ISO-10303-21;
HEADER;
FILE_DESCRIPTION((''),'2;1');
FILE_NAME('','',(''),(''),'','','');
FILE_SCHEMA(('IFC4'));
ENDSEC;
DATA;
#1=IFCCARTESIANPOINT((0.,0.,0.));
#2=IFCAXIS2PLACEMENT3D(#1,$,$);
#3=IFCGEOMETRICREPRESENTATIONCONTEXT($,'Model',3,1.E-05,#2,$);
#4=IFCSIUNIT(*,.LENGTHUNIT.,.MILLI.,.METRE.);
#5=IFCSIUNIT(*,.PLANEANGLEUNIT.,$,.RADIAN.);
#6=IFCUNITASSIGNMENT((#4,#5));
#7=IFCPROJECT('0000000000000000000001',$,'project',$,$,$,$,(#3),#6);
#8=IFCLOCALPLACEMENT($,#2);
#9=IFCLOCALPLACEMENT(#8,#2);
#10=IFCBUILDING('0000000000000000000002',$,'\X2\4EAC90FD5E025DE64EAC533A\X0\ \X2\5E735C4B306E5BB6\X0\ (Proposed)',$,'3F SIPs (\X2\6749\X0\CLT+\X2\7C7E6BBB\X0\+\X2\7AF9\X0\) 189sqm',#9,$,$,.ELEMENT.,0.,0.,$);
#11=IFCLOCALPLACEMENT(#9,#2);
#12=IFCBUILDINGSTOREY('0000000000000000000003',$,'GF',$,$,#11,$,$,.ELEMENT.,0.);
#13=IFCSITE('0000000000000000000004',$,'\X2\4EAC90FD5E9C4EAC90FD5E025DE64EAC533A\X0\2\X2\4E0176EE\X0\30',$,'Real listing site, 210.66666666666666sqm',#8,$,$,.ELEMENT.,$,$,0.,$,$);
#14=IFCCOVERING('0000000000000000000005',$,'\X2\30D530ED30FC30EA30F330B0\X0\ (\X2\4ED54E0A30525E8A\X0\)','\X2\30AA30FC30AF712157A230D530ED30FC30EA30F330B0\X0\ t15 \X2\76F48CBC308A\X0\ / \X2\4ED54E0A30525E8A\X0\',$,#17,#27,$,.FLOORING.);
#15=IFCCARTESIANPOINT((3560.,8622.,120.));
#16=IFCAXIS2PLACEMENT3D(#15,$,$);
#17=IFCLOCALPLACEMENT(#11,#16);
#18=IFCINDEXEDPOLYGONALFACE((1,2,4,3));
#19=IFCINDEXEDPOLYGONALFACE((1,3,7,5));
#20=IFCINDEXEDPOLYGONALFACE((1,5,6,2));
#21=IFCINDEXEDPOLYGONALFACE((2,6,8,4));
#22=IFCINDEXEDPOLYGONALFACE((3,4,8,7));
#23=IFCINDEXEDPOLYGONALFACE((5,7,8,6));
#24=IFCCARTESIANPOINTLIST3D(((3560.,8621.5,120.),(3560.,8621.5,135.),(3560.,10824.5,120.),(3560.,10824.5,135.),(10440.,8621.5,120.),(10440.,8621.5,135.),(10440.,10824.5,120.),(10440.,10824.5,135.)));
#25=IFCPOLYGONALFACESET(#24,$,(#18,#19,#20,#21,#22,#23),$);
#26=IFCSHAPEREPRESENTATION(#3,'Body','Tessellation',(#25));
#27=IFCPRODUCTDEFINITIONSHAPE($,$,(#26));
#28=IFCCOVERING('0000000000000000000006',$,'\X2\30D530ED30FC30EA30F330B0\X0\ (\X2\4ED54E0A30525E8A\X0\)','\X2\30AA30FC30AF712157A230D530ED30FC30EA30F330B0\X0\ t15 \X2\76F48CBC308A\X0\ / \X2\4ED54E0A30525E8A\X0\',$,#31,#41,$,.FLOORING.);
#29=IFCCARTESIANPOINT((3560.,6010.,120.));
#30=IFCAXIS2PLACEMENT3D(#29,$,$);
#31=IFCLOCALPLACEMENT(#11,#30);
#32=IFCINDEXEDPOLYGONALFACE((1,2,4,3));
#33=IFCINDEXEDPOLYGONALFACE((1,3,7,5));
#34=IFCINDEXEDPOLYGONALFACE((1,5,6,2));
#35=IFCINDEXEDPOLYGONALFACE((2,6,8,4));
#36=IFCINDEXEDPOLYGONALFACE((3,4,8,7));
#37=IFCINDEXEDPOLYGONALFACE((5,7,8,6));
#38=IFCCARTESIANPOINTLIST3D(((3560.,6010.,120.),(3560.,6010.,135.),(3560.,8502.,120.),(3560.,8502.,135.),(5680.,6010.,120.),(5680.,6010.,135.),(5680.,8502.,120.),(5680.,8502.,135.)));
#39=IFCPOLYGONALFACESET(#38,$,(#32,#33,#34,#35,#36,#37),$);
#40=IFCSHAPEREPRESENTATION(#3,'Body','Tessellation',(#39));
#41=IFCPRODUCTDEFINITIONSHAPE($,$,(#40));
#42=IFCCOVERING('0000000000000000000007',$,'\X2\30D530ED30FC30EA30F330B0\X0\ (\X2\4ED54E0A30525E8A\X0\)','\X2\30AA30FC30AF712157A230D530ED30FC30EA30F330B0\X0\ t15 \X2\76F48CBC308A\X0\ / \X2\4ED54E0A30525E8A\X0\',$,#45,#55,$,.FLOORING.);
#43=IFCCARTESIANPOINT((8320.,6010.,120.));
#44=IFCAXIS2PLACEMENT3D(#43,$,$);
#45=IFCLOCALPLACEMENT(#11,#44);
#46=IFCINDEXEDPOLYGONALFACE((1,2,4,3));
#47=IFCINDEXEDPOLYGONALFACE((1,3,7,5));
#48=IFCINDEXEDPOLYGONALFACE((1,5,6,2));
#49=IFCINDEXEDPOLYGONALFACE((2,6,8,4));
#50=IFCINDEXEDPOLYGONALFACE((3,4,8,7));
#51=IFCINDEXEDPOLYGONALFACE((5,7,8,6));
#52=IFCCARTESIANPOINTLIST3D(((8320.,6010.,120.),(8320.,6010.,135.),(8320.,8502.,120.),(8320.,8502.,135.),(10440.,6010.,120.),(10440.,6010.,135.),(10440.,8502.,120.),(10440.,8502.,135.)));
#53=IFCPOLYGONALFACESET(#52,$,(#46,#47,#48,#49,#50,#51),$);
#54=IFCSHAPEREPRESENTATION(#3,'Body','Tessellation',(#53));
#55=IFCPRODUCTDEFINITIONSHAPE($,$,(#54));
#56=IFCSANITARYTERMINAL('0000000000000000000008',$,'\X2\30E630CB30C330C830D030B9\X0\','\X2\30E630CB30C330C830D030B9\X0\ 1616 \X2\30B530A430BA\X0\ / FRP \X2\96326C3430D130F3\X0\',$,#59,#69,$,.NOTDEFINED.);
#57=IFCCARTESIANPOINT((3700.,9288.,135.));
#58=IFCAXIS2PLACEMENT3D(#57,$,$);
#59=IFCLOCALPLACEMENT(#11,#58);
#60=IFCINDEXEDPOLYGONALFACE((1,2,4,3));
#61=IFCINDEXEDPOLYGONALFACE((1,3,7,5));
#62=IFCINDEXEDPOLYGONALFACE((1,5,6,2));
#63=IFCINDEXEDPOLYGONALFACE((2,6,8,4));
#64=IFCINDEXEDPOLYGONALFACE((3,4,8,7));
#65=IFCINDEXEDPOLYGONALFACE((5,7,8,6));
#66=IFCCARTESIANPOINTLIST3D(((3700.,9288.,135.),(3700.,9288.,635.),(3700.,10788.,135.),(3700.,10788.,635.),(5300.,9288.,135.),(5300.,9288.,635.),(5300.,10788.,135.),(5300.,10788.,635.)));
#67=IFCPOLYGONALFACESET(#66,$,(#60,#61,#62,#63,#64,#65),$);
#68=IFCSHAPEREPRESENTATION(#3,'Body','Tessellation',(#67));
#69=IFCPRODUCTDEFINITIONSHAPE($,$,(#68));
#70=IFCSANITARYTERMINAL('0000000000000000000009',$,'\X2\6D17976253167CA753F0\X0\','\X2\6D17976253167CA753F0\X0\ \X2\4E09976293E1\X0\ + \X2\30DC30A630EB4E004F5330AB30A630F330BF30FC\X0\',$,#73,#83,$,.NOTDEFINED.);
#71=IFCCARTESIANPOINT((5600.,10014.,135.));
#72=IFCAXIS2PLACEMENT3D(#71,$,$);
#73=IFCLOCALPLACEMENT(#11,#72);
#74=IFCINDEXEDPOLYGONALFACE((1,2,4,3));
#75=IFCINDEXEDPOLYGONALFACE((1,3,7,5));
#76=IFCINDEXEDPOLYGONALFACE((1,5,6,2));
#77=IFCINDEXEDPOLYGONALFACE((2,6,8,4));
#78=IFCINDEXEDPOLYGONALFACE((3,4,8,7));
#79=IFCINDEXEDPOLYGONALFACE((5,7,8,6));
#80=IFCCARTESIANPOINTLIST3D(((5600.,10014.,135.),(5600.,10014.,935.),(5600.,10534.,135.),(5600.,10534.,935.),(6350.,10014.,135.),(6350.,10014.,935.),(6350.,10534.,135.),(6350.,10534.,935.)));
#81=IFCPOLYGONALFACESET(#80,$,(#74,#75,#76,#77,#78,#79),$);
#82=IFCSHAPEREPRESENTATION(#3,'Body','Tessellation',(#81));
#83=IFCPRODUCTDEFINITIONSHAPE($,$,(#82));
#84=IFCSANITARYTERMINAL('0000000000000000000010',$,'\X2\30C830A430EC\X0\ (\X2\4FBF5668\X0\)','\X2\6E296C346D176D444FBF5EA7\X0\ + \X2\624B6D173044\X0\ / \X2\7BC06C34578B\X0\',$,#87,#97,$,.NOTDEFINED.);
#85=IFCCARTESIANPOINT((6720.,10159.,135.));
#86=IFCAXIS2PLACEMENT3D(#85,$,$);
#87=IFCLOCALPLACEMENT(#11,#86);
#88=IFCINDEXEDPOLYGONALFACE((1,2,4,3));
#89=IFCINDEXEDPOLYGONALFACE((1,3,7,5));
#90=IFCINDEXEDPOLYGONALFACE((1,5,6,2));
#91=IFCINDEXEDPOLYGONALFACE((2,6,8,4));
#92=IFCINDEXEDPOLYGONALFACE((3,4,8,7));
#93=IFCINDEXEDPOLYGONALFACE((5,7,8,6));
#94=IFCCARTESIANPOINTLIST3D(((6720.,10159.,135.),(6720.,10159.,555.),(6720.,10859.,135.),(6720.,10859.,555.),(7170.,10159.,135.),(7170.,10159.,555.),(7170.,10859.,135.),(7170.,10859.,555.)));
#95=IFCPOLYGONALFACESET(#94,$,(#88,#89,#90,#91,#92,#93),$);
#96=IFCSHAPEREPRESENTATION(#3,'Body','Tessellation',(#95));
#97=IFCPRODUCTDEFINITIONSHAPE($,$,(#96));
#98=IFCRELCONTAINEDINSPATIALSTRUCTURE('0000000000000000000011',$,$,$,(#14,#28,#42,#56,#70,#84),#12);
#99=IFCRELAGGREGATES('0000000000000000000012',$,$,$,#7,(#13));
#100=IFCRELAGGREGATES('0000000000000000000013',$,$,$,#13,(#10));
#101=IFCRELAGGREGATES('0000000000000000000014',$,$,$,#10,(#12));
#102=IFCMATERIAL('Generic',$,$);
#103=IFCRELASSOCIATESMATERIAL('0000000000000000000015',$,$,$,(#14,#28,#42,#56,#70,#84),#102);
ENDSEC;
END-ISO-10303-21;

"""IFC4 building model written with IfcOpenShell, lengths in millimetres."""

from ifc_helpers import new_model, si_unit, frame, frame_2d, origin, place, context, project, spatial, rectangle, extrude, material, element, save


model = new_model("IFC4")

# Units and contexts
model_context = context("Model", 3, precision=1e-05, world=origin())
ifc_project = project(units=[si_unit("LENGTHUNIT", "METRE", prefix="MILLI"), si_unit("PLANEANGLEUNIT", "RADIAN")], contexts=[model_context])

# Site, building, storey
site_placement = place(None, origin())
site = spatial("IfcSite", under=ifc_project, at=site_placement, Name="京都府京都市左京区2丁目30", ObjectType="Real listing site, 210.66666666666666sqm", CompositionType="ELEMENT", RefElevation=0.0)
building_placement = place(site_placement, origin())
building = spatial("IfcBuilding", under=site, at=building_placement, Name="京都市左京区 平屋の家 (Proposed)", ObjectType="3F SIPs (杉CLT+籾殻+竹) 189sqm", CompositionType="ELEMENT", ElevationOfRefHeight=0.0, ElevationOfTerrain=0.0)
storey_placement = place(building_placement, origin())
storey = spatial("IfcBuildingStorey", under=building, at=storey_placement, Name="GF", CompositionType="ELEMENT", Elevation=0.0)

# Coverings
ifc_material_1 = material(Name="Generic")
covering_1_placement = place(storey_placement, frame((3560.0, 8622.0, 120.0)))
element("IfcCovering", 1, at=covering_1_placement, inside=storey, material=ifc_material_1, Name="フローリング (仕上げ床)", Description="オーク無垢フローリング t15 直貼り / 仕上げ床", PredefinedType="FLOORING", context=model_context, shape_type="SweptSolid", body=[
    extrude(rectangle(XDim=6880.0, YDim=2203.0, at=frame_2d((3440.0, 1101.0))), frame((3560.0, 8622.0, 120.0)), (0.0, 0.0, 1.0), 15.0),
])
covering_2_placement = place(storey_placement, frame((3560.0, 6010.0, 120.0)))
element("IfcCovering", 2, at=covering_2_placement, inside=storey, material=ifc_material_1, Name="フローリング (仕上げ床)", Description="オーク無垢フローリング t15 直貼り / 仕上げ床", PredefinedType="FLOORING", context=model_context, shape_type="SweptSolid", body=[
    extrude(rectangle(XDim=2120.0, YDim=2492.0, at=frame_2d((1060.0, 1246.0))), frame((3560.0, 6010.0, 120.0)), (0.0, 0.0, 1.0), 15.0),
])
covering_3_placement = place(storey_placement, frame((8320.0, 6010.0, 120.0)))
element("IfcCovering", 3, at=covering_3_placement, inside=storey, material=ifc_material_1, Name="フローリング (仕上げ床)", Description="オーク無垢フローリング t15 直貼り / 仕上げ床", PredefinedType="FLOORING", context=model_context, shape_type="SweptSolid", body=[
    extrude(rectangle(XDim=2120.0, YDim=2492.0, at=frame_2d((1060.0, 1246.0))), frame((8320.0, 6010.0, 120.0)), (0.0, 0.0, 1.0), 15.0),
])

# Sanitary terminals
sanitary_terminal_1_placement = place(storey_placement, frame((3700.0, 9288.0, 135.0)))
element("IfcSanitaryTerminal", 4, at=sanitary_terminal_1_placement, inside=storey, material=ifc_material_1, Name="ユニットバス", Description="ユニットバス 1616 サイズ / FRP 防水パン", PredefinedType="NOTDEFINED", context=model_context, shape_type="SweptSolid", body=[
    extrude(rectangle(XDim=1600.0, YDim=1500.0, at=frame_2d((800.0, 750.0))), frame((3700.0, 9288.0, 135.0)), (0.0, 0.0, 1.0), 500.0),
])
sanitary_terminal_2_placement = place(storey_placement, frame((5600.0, 10014.0, 135.0)))
element("IfcSanitaryTerminal", 5, at=sanitary_terminal_2_placement, inside=storey, material=ifc_material_1, Name="洗面化粧台", Description="洗面化粧台 三面鏡 + ボウル一体カウンター", PredefinedType="NOTDEFINED", context=model_context, shape_type="SweptSolid", body=[
    extrude(rectangle(XDim=750.0, YDim=520.0, at=frame_2d((375.0, 260.0))), frame((5600.0, 10014.0, 135.0)), (0.0, 0.0, 1.0), 800.0),
])
sanitary_terminal_3_placement = place(storey_placement, frame((6720.0, 10159.0, 135.0)))
element("IfcSanitaryTerminal", 6, at=sanitary_terminal_3_placement, inside=storey, material=ifc_material_1, Name="トイレ (便器)", Description="温水洗浄便座 + 手洗い / 節水型", PredefinedType="NOTDEFINED", context=model_context, shape_type="SweptSolid", body=[
    extrude(rectangle(XDim=450.0, YDim=700.0, at=frame_2d((225.0, 350.0))), frame((6720.0, 10159.0, 135.0)), (0.0, 0.0, 1.0), 420.0),
])

save(model, "model.ifc")
